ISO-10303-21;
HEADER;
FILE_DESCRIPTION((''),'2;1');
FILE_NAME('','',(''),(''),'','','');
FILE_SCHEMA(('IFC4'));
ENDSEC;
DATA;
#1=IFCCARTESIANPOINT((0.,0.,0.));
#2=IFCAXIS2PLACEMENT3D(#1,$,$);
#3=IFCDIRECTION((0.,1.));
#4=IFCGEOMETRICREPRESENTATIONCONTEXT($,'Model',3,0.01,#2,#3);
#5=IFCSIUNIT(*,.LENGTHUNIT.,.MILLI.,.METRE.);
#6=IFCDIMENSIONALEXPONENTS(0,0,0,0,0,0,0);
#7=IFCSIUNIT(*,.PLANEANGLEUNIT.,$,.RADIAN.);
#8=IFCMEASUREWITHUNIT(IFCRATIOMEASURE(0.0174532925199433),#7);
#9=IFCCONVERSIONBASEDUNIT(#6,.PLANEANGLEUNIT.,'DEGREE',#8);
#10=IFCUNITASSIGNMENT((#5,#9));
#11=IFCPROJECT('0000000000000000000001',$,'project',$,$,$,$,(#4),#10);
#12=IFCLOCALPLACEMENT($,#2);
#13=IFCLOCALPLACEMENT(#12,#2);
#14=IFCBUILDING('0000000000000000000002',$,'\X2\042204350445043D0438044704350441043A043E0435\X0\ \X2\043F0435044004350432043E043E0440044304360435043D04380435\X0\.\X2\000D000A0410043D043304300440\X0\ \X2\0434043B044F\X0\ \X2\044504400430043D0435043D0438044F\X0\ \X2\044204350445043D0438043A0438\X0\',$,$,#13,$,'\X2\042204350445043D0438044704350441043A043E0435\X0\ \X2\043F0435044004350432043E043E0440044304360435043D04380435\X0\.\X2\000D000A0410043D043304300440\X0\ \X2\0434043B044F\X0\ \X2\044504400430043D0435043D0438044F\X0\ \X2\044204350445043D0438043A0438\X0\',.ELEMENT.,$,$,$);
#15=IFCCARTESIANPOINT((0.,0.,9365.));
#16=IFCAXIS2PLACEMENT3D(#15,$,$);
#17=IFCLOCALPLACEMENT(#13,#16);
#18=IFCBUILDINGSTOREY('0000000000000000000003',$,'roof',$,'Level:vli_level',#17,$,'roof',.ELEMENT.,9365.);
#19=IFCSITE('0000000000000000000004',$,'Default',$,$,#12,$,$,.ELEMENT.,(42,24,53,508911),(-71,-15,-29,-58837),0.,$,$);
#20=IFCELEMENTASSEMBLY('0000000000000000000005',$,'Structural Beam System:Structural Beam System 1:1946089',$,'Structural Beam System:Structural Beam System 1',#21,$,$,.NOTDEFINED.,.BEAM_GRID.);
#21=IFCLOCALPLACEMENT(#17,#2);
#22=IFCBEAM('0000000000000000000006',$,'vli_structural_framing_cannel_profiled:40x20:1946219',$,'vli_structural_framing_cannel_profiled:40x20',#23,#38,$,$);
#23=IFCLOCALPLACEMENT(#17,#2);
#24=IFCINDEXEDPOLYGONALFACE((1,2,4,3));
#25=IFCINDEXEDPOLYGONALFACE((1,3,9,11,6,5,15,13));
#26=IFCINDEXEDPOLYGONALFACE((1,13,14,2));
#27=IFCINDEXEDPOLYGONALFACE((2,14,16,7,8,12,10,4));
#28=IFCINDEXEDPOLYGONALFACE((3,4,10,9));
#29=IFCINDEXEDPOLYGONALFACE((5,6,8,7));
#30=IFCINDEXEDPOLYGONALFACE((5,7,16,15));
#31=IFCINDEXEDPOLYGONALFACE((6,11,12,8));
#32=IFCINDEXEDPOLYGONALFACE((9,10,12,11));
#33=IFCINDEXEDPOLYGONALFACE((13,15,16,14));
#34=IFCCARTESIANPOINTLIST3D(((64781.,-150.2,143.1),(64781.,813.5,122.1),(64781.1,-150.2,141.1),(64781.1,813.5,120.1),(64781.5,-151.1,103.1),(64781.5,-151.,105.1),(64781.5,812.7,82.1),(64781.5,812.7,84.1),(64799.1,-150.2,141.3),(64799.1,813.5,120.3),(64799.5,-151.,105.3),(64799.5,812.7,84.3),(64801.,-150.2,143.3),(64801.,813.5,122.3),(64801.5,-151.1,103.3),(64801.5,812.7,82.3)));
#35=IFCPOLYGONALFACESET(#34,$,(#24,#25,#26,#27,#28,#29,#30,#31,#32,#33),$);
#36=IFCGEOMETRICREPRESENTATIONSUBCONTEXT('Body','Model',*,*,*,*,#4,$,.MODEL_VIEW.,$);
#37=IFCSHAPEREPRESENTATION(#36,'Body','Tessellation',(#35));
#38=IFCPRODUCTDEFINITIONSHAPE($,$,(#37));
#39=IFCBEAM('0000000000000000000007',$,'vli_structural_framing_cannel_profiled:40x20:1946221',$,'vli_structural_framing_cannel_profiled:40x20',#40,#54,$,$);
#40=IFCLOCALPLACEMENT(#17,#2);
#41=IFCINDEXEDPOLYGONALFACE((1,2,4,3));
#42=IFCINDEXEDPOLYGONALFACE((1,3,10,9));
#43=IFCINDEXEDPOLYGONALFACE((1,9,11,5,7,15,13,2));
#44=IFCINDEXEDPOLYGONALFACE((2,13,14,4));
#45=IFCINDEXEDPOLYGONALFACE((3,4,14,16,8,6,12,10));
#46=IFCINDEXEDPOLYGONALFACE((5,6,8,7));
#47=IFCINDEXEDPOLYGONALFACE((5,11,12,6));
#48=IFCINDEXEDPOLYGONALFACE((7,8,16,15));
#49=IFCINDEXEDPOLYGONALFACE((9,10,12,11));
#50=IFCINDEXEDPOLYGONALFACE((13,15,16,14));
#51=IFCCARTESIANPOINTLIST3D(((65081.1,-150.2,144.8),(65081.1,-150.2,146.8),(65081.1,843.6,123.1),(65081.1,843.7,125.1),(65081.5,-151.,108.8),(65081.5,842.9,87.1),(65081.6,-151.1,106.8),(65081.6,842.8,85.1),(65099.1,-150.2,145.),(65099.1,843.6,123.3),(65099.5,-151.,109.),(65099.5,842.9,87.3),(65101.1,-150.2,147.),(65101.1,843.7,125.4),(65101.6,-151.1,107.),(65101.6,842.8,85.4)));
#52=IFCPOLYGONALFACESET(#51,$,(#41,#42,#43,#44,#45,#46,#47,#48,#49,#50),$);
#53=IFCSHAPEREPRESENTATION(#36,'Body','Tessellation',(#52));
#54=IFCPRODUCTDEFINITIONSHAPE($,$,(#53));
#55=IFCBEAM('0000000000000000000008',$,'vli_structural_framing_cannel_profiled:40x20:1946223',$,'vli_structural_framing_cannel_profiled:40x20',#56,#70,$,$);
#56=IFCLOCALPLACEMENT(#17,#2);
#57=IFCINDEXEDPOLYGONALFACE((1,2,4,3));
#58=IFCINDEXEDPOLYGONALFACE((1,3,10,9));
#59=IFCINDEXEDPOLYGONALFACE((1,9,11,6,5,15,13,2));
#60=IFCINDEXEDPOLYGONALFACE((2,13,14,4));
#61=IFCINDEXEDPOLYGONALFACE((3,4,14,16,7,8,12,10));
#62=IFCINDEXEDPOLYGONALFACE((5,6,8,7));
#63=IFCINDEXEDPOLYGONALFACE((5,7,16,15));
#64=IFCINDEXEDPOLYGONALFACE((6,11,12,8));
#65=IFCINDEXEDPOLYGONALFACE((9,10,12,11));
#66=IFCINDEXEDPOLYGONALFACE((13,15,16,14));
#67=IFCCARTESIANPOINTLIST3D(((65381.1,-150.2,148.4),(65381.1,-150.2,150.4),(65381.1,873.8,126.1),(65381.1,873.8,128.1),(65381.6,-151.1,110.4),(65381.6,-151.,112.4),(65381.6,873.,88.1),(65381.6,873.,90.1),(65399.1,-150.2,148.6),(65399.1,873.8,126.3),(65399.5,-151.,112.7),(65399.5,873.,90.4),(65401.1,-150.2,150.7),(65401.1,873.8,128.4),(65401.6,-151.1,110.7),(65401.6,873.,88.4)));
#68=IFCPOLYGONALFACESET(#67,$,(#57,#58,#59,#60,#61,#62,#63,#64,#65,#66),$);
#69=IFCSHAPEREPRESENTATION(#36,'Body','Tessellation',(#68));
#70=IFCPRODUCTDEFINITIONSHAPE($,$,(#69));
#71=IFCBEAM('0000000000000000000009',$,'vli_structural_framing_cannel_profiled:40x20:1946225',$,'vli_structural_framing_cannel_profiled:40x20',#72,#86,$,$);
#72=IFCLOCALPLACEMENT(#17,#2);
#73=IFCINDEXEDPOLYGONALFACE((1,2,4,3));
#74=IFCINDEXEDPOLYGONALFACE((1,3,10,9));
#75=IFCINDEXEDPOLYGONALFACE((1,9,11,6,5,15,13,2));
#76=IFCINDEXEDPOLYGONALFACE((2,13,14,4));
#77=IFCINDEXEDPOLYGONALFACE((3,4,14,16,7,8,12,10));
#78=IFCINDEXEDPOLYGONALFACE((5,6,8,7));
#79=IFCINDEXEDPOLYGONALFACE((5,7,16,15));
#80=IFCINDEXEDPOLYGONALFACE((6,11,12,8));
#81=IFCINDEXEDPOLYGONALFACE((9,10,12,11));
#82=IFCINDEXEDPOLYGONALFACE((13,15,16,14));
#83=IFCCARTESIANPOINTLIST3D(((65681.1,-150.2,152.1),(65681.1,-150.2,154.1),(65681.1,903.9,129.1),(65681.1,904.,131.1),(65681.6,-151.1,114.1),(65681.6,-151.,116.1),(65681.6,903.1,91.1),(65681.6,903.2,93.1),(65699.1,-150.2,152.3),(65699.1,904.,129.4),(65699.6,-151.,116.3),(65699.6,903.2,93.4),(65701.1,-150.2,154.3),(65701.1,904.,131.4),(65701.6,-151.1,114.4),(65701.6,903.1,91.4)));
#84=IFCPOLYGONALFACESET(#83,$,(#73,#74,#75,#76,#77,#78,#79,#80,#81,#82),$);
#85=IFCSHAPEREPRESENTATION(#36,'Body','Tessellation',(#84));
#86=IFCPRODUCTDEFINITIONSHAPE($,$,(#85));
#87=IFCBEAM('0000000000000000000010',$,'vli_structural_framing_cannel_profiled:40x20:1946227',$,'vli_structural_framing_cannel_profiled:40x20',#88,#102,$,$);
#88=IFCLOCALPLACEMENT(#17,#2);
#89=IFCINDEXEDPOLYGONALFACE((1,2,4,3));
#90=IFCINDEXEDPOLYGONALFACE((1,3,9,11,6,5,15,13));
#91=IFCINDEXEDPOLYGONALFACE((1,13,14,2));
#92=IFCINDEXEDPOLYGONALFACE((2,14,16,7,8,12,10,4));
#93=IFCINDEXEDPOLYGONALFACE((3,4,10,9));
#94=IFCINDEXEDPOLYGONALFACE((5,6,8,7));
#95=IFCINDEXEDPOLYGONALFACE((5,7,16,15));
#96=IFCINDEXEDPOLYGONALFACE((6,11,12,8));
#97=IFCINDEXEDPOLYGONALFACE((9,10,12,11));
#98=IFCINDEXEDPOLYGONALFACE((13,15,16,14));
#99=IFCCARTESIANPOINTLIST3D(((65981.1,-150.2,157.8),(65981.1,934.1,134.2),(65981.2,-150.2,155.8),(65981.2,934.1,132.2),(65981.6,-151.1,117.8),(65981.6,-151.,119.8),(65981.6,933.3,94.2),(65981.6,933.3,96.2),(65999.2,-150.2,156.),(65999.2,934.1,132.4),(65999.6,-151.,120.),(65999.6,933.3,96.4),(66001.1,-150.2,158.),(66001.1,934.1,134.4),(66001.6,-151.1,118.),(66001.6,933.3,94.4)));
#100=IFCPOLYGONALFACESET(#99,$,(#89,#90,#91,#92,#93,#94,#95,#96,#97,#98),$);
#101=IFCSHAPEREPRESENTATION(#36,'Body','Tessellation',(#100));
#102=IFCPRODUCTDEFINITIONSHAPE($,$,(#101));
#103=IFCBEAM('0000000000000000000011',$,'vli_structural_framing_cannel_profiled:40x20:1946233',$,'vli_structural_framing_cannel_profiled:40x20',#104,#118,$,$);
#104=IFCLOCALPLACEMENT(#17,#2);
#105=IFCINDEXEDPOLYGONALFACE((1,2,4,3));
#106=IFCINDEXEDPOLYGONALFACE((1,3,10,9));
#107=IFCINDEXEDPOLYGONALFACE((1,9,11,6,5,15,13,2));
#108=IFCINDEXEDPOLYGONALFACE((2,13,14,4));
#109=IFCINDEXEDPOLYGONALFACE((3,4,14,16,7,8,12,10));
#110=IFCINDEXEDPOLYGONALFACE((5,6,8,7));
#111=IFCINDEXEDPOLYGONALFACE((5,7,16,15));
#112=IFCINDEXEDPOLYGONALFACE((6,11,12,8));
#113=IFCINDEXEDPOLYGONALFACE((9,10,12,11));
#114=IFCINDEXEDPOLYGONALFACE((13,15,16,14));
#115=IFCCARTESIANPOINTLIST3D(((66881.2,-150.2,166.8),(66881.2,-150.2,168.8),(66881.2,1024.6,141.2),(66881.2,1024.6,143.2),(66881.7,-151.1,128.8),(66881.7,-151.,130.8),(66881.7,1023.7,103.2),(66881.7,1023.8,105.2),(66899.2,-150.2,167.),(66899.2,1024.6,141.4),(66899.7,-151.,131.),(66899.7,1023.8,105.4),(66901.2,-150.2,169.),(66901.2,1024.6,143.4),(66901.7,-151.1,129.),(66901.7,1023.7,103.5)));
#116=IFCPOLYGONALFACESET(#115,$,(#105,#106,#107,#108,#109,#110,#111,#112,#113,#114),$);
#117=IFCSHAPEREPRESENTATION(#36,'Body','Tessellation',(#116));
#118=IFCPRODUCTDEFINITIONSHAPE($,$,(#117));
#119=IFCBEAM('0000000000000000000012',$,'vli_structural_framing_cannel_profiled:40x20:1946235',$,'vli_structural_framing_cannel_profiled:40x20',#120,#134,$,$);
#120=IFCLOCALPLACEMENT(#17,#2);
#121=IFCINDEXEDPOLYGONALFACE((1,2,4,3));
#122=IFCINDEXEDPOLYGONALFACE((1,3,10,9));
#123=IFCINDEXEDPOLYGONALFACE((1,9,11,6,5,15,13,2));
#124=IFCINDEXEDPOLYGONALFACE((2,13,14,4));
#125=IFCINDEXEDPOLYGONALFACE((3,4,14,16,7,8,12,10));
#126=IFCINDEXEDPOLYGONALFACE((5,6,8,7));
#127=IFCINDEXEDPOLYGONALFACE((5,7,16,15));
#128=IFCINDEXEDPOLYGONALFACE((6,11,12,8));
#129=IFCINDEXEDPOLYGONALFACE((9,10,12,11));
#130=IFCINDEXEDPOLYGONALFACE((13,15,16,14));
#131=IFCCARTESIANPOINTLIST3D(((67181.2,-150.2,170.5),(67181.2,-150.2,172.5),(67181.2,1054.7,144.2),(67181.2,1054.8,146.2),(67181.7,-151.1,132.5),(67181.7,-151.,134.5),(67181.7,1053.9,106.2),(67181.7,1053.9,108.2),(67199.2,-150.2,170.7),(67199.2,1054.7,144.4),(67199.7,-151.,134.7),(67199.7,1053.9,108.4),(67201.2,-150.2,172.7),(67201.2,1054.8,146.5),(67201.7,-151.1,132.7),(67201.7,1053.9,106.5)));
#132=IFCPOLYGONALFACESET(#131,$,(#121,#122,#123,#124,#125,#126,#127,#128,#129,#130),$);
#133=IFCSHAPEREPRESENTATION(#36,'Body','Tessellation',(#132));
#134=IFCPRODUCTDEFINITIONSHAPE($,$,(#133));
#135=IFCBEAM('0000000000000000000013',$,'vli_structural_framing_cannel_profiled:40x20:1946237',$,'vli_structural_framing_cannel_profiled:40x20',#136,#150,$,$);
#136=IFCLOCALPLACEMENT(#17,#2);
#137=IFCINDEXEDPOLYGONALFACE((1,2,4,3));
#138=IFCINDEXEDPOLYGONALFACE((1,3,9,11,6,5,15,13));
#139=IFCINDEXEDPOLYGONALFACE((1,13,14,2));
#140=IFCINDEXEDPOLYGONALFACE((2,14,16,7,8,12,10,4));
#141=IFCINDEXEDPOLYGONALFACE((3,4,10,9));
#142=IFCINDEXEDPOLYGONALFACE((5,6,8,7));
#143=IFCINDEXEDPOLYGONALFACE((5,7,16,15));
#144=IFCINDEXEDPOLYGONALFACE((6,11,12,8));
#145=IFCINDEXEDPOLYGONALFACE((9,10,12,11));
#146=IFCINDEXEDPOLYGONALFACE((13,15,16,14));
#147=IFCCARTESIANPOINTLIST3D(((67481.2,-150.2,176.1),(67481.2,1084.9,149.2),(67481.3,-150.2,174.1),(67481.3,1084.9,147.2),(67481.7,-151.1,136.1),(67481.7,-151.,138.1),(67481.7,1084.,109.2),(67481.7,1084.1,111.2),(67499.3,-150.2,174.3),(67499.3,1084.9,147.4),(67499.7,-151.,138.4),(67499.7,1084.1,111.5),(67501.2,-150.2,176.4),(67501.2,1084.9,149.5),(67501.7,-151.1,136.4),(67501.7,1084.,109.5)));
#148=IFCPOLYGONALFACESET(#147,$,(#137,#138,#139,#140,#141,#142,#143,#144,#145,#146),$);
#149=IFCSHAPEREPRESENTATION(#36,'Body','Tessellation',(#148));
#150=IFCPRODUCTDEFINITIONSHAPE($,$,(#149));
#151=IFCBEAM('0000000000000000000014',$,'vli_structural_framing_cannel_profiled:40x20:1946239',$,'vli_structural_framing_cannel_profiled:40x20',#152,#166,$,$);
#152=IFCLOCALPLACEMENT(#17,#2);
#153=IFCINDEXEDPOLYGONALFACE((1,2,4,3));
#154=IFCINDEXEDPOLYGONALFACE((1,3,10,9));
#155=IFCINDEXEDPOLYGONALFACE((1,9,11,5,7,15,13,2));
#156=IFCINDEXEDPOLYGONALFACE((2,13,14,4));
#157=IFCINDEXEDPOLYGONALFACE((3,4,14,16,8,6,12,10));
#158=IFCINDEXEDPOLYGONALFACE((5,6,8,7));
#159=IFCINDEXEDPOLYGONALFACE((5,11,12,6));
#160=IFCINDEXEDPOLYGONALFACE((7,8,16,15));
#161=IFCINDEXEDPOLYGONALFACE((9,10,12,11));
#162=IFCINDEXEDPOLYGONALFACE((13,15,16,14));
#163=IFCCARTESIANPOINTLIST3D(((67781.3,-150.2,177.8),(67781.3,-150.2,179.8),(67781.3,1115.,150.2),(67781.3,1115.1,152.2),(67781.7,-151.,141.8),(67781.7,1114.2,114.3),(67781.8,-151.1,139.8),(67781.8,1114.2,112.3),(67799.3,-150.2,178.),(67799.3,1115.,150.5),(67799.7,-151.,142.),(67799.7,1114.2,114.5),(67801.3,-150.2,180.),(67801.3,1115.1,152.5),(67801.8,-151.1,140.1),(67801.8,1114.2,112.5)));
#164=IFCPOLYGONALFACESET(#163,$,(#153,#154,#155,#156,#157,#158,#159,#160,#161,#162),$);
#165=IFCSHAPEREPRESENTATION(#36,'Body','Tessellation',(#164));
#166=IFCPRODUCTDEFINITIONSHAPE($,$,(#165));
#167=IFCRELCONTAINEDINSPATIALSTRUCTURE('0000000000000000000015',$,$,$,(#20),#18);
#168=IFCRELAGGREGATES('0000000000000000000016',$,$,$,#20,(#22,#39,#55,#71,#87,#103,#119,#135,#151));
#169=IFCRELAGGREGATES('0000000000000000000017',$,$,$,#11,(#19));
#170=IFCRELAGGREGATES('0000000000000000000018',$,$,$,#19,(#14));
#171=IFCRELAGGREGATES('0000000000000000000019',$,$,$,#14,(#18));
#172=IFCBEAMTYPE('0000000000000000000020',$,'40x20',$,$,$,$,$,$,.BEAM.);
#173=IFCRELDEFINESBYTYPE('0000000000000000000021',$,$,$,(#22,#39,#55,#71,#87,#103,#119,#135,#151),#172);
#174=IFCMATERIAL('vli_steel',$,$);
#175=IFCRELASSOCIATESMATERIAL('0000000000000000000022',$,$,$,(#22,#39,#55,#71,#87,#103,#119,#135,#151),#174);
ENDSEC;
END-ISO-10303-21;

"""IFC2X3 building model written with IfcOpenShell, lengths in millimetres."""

from ifc_helpers import new_model, entity, si_unit, converted_unit, direction, frame, origin, place, context, subcontext, project, spatial, polyline, outline, extrude, material, type_object, element, aggregate, save


model = new_model("IFC2X3")

# Units and contexts
model_context = context("Model", 3, precision=0.01, world=origin(), true_north=direction((0.0, 1.0)))
body_context = subcontext(model_context, "Body", "Model", "MODEL_VIEW")
ifc_project = project(units=[si_unit("LENGTHUNIT", "METRE", prefix="MILLI"), converted_unit("PLANEANGLEUNIT", "DEGREE", entity("IfcRatioMeasure", 0.0174532925199433), si_unit("PLANEANGLEUNIT", "RADIAN"), dimensions=[0, 0, 0, 0, 0, 0, 0])], contexts=[model_context])

# Site, building, storey
site_placement = place(None, origin())
site = spatial("IfcSite", under=ifc_project, at=site_placement, Name="Default", CompositionType="ELEMENT", RefLatitude=(42, 24, 53, 508911), RefLongitude=(-71, -15, -29, -58837), RefElevation=0.0)
building_placement = place(site_placement, origin())
building = spatial("IfcBuilding", under=site, at=building_placement, Name="Техническое перевооружение.\r\nАнгар для хранения техники", LongName="Техническое перевооружение.\r\nАнгар для хранения техники", CompositionType="ELEMENT")
storey_placement = place(building_placement, frame((0.0, 0.0, 9365.0)))
storey = spatial("IfcBuildingStorey", under=building, at=storey_placement, Name="roof", ObjectType="Level:vli_level", LongName="roof", CompositionType="ELEMENT", Elevation=9365.0)

# Element assembly, beams
ifc_material = material(Name="vli_steel")
beam_type = type_object("IfcBeamType", Name="40x20", PredefinedType="BEAM")
assembly_1_placement = place(storey_placement, origin())
assembly_1 = element("IfcElementAssembly", 1, at=assembly_1_placement, inside=storey, Name="Structural Beam System:Structural Beam System 1:1946089", ObjectType="Structural Beam System:Structural Beam System 1", AssemblyPlace="NOTDEFINED", PredefinedType="BEAM_GRID")
beam_1_placement = place(assembly_1_placement, frame((64800.4, 813.5, 122.3), z_axis=(0.0, 0.021775, 0.999763), x_axis=(0.0, -0.999763, 0.021775)))
beam_1 = element("IfcBeam", 2, at=beam_1_placement, type_object=beam_type, material=ifc_material, Name="vli_structural_framing_cannel_profiled:40x20:1946219", ObjectType="vli_structural_framing_cannel_profiled:40x20", context=body_context, shape_type="SweptSolid", body=[
    extrude(outline(polyline([(-10.5, -20.0), (9.5, -20.0), (9.5, -18.0), (-8.5, -18.0), (-8.5, 18.0), (9.5, 18.0), (9.5, 20.0), (-10.5, 20.0), (-10.5, -20.0)])), frame((0.0, -9.7, -20.1), z_axis=(1.0, 0.0, 0.0), x_axis=(0.0, -0.999925, -0.01227)), (0.0, 0.0, 1.0), 964.0),
])
beam_2_placement = place(assembly_1_placement, frame((65100.5, 843.7, 125.3), z_axis=(0.0, 0.021775, 0.999763), x_axis=(0.0, -0.999763, 0.021775)))
beam_2 = element("IfcBeam", 3, at=beam_2_placement, type_object=beam_type, material=ifc_material, Name="vli_structural_framing_cannel_profiled:40x20:1946221", ObjectType="vli_structural_framing_cannel_profiled:40x20", context=body_context, shape_type="SweptSolid", body=[
    extrude(outline(polyline([(-10.5, -20.0), (9.5, -20.0), (9.5, -18.0), (-8.5, -18.0), (-8.5, 18.0), (9.5, 18.0), (9.5, 20.0), (-10.5, 20.0), (-10.5, -20.0)])), frame((0.0, -9.7, -20.1), z_axis=(1.0, 0.0, 0.0), x_axis=(0.0, -0.999925, -0.01227)), (0.0, 0.0, 1.0), 994.1),
])
beam_3_placement = place(assembly_1_placement, frame((65400.5, 873.8, 128.4), z_axis=(0.0, 0.021775, 0.999763), x_axis=(0.0, -0.999763, 0.021775)))
beam_3 = element("IfcBeam", 4, at=beam_3_placement, type_object=beam_type, material=ifc_material, Name="vli_structural_framing_cannel_profiled:40x20:1946223", ObjectType="vli_structural_framing_cannel_profiled:40x20", context=body_context, shape_type="SweptSolid", body=[
    extrude(outline(polyline([(-10.5, -20.0), (9.5, -20.0), (9.5, -18.0), (-8.5, -18.0), (-8.5, 18.0), (9.5, 18.0), (9.5, 20.0), (-10.5, 20.0), (-10.5, -20.0)])), frame((0.0, -9.7, -20.1), z_axis=(1.0, 0.0, 0.0), x_axis=(0.0, -0.999925, -0.01227)), (0.0, 0.0, 1.0), 1024.3),
])
beam_4_placement = place(assembly_1_placement, frame((65700.5, 904.0, 131.4), z_axis=(0.0, 0.021775, 0.999763), x_axis=(0.0, -0.999763, 0.021775)))
beam_4 = element("IfcBeam", 5, at=beam_4_placement, type_object=beam_type, material=ifc_material, Name="vli_structural_framing_cannel_profiled:40x20:1946225", ObjectType="vli_structural_framing_cannel_profiled:40x20", context=body_context, shape_type="SweptSolid", body=[
    extrude(outline(polyline([(-10.5, -20.0), (9.5, -20.0), (9.5, -18.0), (-8.5, -18.0), (-8.5, 18.0), (9.5, 18.0), (9.5, 20.0), (-10.5, 20.0), (-10.5, -20.0)])), frame((0.0, -9.7, -20.1), z_axis=(1.0, 0.0, 0.0), x_axis=(0.0, -0.999925, -0.01227)), (0.0, 0.0, 1.0), 1054.4),
])
beam_5_placement = place(assembly_1_placement, frame((66000.5, 934.1, 134.4), z_axis=(0.0, 0.021775, 0.999763), x_axis=(0.0, -0.999763, 0.021775)))
beam_5 = element("IfcBeam", 6, at=beam_5_placement, type_object=beam_type, material=ifc_material, Name="vli_structural_framing_cannel_profiled:40x20:1946227", ObjectType="vli_structural_framing_cannel_profiled:40x20", context=body_context, shape_type="SweptSolid", body=[
    extrude(outline(polyline([(-10.5, -20.0), (9.5, -20.0), (9.5, -18.0), (-8.5, -18.0), (-8.5, 18.0), (9.5, 18.0), (9.5, 20.0), (-10.5, 20.0), (-10.5, -20.0)])), frame((0.0, -9.7, -20.1), z_axis=(1.0, 0.0, 0.0), x_axis=(0.0, -0.999925, -0.01227)), (0.0, 0.0, 1.0), 1084.6),
])
beam_6_placement = place(assembly_1_placement, frame((66900.6, 1024.6, 143.4), z_axis=(0.0, 0.021775, 0.999763), x_axis=(0.0, -0.999763, 0.021775)))
beam_6 = element("IfcBeam", 7, at=beam_6_placement, type_object=beam_type, material=ifc_material, Name="vli_structural_framing_cannel_profiled:40x20:1946233", ObjectType="vli_structural_framing_cannel_profiled:40x20", context=body_context, shape_type="SweptSolid", body=[
    extrude(outline(polyline([(-10.5, -20.0), (9.5, -20.0), (9.5, -18.0), (-8.5, -18.0), (-8.5, 18.0), (9.5, 18.0), (9.5, 20.0), (-10.5, 20.0), (-10.5, -20.0)])), frame((0.0, -9.7, -20.1), z_axis=(1.0, 0.0, 0.0), x_axis=(0.0, -0.999925, -0.01227)), (0.0, 0.0, 1.0), 1175.1),
])
beam_7_placement = place(assembly_1_placement, frame((67200.6, 1054.8, 146.5), z_axis=(0.0, 0.021775, 0.999763), x_axis=(0.0, -0.999763, 0.021775)))
beam_7 = element("IfcBeam", 8, at=beam_7_placement, type_object=beam_type, material=ifc_material, Name="vli_structural_framing_cannel_profiled:40x20:1946235", ObjectType="vli_structural_framing_cannel_profiled:40x20", context=body_context, shape_type="SweptSolid", body=[
    extrude(outline(polyline([(-10.5, -20.0), (9.5, -20.0), (9.5, -18.0), (-8.5, -18.0), (-8.5, 18.0), (9.5, 18.0), (9.5, 20.0), (-10.5, 20.0), (-10.5, -20.0)])), frame((0.0, -9.7, -20.1), z_axis=(1.0, 0.0, 0.0), x_axis=(0.0, -0.999925, -0.01227)), (0.0, 0.0, 1.0), 1205.2),
])
beam_8_placement = place(assembly_1_placement, frame((67500.6, 1084.9, 149.5), z_axis=(0.0, 0.021775, 0.999763), x_axis=(0.0, -0.999763, 0.021775)))
beam_8 = element("IfcBeam", 9, at=beam_8_placement, type_object=beam_type, material=ifc_material, Name="vli_structural_framing_cannel_profiled:40x20:1946237", ObjectType="vli_structural_framing_cannel_profiled:40x20", context=body_context, shape_type="SweptSolid", body=[
    extrude(outline(polyline([(-10.5, -20.0), (9.5, -20.0), (9.5, -18.0), (-8.5, -18.0), (-8.5, 18.0), (9.5, 18.0), (9.5, 20.0), (-10.5, 20.0), (-10.5, -20.0)])), frame((0.0, -9.7, -20.1), z_axis=(1.0, 0.0, 0.0), x_axis=(0.0, -0.999925, -0.01227)), (0.0, 0.0, 1.0), 1235.4),
])
beam_9_placement = place(assembly_1_placement, frame((67800.7, 1115.1, 152.5), z_axis=(0.0, 0.021775, 0.999763), x_axis=(0.0, -0.999763, 0.021775)))
beam_9 = element("IfcBeam", 10, at=beam_9_placement, type_object=beam_type, material=ifc_material, Name="vli_structural_framing_cannel_profiled:40x20:1946239", ObjectType="vli_structural_framing_cannel_profiled:40x20", context=body_context, shape_type="SweptSolid", body=[
    extrude(outline(polyline([(-10.5, -20.0), (9.5, -20.0), (9.5, -18.0), (-8.5, -18.0), (-8.5, 18.0), (9.5, 18.0), (9.5, 20.0), (-10.5, 20.0), (-10.5, -20.0)])), frame((0.0, -9.7, -20.1), z_axis=(1.0, 0.0, 0.0), x_axis=(0.0, -0.999925, -0.01227)), (0.0, 0.0, 1.0), 1265.6),
])
aggregate(assembly_1, [beam_1, beam_2, beam_3, beam_4, beam_5, beam_6, beam_7, beam_8, beam_9])

save(model, "model.ifc")
